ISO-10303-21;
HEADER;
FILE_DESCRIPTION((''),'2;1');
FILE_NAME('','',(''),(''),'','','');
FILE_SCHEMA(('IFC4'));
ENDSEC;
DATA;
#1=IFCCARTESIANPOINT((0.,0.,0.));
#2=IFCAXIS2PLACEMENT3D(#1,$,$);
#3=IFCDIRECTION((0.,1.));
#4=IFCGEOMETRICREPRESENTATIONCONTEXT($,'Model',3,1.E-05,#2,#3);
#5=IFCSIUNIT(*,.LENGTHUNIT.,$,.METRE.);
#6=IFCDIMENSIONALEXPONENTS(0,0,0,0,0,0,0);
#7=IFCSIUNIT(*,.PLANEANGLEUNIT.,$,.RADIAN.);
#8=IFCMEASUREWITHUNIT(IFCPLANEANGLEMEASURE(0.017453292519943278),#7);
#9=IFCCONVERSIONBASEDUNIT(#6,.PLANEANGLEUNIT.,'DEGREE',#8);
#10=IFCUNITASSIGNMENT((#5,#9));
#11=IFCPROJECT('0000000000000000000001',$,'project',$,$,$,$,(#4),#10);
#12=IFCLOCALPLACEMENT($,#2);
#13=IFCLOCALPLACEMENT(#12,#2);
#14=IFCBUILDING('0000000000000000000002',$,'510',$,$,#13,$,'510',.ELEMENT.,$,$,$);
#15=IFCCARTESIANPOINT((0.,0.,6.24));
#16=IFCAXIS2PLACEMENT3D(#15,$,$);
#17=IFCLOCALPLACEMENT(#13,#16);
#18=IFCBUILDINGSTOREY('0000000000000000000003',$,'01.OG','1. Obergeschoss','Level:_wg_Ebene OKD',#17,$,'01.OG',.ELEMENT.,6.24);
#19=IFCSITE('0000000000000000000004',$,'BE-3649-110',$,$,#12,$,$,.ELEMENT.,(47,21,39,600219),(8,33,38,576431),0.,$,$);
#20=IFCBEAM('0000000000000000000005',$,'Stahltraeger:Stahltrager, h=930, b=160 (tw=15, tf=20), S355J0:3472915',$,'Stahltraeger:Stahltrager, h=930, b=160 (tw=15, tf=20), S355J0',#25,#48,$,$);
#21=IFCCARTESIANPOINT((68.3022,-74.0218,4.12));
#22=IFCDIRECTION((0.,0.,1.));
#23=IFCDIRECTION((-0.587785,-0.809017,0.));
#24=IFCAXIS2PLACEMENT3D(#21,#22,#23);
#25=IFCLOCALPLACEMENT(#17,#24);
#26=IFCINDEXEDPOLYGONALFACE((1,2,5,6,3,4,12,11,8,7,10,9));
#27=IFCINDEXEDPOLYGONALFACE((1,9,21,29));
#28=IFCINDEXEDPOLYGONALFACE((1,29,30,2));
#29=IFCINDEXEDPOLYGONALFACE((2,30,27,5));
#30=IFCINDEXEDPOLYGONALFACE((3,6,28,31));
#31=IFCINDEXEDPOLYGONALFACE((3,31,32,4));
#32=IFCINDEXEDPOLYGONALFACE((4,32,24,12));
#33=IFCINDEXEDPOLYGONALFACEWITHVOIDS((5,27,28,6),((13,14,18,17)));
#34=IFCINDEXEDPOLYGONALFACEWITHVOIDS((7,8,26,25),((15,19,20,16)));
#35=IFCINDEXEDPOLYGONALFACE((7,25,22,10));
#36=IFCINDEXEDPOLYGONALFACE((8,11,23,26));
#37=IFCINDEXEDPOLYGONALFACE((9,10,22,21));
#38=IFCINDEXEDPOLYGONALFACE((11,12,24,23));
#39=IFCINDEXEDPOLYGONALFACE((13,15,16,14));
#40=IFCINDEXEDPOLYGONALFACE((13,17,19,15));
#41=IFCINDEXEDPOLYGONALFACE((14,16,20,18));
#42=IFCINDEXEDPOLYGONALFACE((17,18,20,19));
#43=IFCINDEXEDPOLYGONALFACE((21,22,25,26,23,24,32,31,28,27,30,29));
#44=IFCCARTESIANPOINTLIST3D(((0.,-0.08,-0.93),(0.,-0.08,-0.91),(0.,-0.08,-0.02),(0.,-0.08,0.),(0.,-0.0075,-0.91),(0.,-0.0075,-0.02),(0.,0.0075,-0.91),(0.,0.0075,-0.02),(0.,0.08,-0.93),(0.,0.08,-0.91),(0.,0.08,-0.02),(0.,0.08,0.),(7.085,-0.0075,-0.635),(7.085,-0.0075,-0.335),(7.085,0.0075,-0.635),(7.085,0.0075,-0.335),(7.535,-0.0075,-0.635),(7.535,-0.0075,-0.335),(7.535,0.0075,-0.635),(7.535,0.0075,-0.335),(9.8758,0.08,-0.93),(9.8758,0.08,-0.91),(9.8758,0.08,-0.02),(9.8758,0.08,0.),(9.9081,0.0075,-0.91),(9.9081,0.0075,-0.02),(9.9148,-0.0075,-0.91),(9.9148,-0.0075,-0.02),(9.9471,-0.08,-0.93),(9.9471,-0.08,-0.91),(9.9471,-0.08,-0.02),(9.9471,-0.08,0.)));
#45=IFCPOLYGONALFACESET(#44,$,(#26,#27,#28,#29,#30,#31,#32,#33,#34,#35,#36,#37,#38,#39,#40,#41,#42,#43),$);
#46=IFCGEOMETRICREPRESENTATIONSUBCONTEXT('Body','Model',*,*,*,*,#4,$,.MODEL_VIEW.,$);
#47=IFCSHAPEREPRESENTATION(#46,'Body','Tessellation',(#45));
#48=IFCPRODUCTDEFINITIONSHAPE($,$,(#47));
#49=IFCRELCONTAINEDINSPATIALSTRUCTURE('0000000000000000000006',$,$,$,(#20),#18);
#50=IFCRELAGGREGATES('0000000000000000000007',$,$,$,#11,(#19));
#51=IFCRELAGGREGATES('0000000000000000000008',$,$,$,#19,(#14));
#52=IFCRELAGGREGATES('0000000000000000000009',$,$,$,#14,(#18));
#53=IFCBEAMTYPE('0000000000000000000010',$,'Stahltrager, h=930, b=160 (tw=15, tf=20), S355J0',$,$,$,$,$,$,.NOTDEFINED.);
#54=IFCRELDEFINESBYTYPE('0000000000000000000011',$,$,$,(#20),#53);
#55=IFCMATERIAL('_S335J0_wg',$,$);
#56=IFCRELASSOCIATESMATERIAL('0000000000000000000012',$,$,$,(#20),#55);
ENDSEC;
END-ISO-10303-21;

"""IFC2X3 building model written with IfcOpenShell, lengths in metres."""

from ifc_helpers import new_model, entity, si_unit, converted_unit, direction, frame, frame_2d, origin, place, context, subcontext, project, spatial, rectangle, i_section, extrude, boolean, clip, halfspace, material, type_object, element, save


model = new_model("IFC2X3")

# Units and contexts
model_context = context("Model", 3, precision=1e-05, world=origin(), true_north=direction((0.0, 1.0)))
body_context = subcontext(model_context, "Body", "Model", "MODEL_VIEW")
ifc_project = project(units=[si_unit("LENGTHUNIT", "METRE"), converted_unit("PLANEANGLEUNIT", "DEGREE", entity("IfcPlaneAngleMeasure", 0.017453292519943278), si_unit("PLANEANGLEUNIT", "RADIAN"), dimensions=[0, 0, 0, 0, 0, 0, 0])], contexts=[model_context])

# Site, building, storey
site_placement = place(None, origin())
site = spatial("IfcSite", under=ifc_project, at=site_placement, Name="BE-3649-110", CompositionType="ELEMENT", RefLatitude=(47, 21, 39, 600219), RefLongitude=(8, 33, 38, 576431), RefElevation=0.0)
building_placement = place(site_placement, origin())
building = spatial("IfcBuilding", under=site, at=building_placement, Name="510", LongName="510", CompositionType="ELEMENT")
storey_placement = place(building_placement, frame((0.0, 0.0, 6.24)))
storey = spatial("IfcBuildingStorey", under=building, at=storey_placement, Name="01.OG", Description="1. Obergeschoss", ObjectType="Level:_wg_Ebene OKD", LongName="01.OG", CompositionType="ELEMENT", Elevation=6.24)

# Beam
ifc_material_1 = material(Name="_S335J0_wg")
beam_type_1 = type_object("IfcBeamType", Name="Stahltrager, h=930, b=160 (tw=15, tf=20), S355J0", PredefinedType="NOTDEFINED")
beam_1_placement = place(storey_placement, frame((68.3022, -74.0218, 4.12), z_axis=(0.0, 0.0, 1.0), x_axis=(-0.587785, -0.809017, 0.0)))
element("IfcBeam", 1, at=beam_1_placement, inside=storey, type_object=beam_type_1, material=ifc_material_1, Name="Stahltraeger:Stahltrager, h=930, b=160 (tw=15, tf=20), S355J0:3472915", ObjectType="Stahltraeger:Stahltrager, h=930, b=160 (tw=15, tf=20), S355J0", context=body_context, shape_type="SweptSolid", body=[
    boolean("DIFFERENCE", clip(extrude(i_section(OverallWidth=0.16, OverallDepth=0.93, WebThickness=0.015, FlangeThickness=0.02, at=frame_2d((0.0, 0.0), x_axis=(0.0, 1.0))), frame((0.0, 0.0, -0.465), z_axis=(1.0, 0.0, 0.0), x_axis=(0.0, 0.0, -1.0)), (0.0, 0.0, 1.0), 9.947), halfspace(frame((9.6978, 0.4799, -10.58), z_axis=(0.913545, 0.406737, 0.0), x_axis=(0.406737, -0.913545, 0.0)), False)), extrude(rectangle(XDim=0.3, YDim=0.45, at=frame_2d((0.0, 0.0), x_axis=(0.0, 1.0))), frame((7.31, 0.0075, -0.485), z_axis=(0.0, -1.0, 0.0), x_axis=(-1.0, 0.0, 0.0)), (0.0, 0.0, 1.0), 0.015)),
])

save(model, "model.ifc")
